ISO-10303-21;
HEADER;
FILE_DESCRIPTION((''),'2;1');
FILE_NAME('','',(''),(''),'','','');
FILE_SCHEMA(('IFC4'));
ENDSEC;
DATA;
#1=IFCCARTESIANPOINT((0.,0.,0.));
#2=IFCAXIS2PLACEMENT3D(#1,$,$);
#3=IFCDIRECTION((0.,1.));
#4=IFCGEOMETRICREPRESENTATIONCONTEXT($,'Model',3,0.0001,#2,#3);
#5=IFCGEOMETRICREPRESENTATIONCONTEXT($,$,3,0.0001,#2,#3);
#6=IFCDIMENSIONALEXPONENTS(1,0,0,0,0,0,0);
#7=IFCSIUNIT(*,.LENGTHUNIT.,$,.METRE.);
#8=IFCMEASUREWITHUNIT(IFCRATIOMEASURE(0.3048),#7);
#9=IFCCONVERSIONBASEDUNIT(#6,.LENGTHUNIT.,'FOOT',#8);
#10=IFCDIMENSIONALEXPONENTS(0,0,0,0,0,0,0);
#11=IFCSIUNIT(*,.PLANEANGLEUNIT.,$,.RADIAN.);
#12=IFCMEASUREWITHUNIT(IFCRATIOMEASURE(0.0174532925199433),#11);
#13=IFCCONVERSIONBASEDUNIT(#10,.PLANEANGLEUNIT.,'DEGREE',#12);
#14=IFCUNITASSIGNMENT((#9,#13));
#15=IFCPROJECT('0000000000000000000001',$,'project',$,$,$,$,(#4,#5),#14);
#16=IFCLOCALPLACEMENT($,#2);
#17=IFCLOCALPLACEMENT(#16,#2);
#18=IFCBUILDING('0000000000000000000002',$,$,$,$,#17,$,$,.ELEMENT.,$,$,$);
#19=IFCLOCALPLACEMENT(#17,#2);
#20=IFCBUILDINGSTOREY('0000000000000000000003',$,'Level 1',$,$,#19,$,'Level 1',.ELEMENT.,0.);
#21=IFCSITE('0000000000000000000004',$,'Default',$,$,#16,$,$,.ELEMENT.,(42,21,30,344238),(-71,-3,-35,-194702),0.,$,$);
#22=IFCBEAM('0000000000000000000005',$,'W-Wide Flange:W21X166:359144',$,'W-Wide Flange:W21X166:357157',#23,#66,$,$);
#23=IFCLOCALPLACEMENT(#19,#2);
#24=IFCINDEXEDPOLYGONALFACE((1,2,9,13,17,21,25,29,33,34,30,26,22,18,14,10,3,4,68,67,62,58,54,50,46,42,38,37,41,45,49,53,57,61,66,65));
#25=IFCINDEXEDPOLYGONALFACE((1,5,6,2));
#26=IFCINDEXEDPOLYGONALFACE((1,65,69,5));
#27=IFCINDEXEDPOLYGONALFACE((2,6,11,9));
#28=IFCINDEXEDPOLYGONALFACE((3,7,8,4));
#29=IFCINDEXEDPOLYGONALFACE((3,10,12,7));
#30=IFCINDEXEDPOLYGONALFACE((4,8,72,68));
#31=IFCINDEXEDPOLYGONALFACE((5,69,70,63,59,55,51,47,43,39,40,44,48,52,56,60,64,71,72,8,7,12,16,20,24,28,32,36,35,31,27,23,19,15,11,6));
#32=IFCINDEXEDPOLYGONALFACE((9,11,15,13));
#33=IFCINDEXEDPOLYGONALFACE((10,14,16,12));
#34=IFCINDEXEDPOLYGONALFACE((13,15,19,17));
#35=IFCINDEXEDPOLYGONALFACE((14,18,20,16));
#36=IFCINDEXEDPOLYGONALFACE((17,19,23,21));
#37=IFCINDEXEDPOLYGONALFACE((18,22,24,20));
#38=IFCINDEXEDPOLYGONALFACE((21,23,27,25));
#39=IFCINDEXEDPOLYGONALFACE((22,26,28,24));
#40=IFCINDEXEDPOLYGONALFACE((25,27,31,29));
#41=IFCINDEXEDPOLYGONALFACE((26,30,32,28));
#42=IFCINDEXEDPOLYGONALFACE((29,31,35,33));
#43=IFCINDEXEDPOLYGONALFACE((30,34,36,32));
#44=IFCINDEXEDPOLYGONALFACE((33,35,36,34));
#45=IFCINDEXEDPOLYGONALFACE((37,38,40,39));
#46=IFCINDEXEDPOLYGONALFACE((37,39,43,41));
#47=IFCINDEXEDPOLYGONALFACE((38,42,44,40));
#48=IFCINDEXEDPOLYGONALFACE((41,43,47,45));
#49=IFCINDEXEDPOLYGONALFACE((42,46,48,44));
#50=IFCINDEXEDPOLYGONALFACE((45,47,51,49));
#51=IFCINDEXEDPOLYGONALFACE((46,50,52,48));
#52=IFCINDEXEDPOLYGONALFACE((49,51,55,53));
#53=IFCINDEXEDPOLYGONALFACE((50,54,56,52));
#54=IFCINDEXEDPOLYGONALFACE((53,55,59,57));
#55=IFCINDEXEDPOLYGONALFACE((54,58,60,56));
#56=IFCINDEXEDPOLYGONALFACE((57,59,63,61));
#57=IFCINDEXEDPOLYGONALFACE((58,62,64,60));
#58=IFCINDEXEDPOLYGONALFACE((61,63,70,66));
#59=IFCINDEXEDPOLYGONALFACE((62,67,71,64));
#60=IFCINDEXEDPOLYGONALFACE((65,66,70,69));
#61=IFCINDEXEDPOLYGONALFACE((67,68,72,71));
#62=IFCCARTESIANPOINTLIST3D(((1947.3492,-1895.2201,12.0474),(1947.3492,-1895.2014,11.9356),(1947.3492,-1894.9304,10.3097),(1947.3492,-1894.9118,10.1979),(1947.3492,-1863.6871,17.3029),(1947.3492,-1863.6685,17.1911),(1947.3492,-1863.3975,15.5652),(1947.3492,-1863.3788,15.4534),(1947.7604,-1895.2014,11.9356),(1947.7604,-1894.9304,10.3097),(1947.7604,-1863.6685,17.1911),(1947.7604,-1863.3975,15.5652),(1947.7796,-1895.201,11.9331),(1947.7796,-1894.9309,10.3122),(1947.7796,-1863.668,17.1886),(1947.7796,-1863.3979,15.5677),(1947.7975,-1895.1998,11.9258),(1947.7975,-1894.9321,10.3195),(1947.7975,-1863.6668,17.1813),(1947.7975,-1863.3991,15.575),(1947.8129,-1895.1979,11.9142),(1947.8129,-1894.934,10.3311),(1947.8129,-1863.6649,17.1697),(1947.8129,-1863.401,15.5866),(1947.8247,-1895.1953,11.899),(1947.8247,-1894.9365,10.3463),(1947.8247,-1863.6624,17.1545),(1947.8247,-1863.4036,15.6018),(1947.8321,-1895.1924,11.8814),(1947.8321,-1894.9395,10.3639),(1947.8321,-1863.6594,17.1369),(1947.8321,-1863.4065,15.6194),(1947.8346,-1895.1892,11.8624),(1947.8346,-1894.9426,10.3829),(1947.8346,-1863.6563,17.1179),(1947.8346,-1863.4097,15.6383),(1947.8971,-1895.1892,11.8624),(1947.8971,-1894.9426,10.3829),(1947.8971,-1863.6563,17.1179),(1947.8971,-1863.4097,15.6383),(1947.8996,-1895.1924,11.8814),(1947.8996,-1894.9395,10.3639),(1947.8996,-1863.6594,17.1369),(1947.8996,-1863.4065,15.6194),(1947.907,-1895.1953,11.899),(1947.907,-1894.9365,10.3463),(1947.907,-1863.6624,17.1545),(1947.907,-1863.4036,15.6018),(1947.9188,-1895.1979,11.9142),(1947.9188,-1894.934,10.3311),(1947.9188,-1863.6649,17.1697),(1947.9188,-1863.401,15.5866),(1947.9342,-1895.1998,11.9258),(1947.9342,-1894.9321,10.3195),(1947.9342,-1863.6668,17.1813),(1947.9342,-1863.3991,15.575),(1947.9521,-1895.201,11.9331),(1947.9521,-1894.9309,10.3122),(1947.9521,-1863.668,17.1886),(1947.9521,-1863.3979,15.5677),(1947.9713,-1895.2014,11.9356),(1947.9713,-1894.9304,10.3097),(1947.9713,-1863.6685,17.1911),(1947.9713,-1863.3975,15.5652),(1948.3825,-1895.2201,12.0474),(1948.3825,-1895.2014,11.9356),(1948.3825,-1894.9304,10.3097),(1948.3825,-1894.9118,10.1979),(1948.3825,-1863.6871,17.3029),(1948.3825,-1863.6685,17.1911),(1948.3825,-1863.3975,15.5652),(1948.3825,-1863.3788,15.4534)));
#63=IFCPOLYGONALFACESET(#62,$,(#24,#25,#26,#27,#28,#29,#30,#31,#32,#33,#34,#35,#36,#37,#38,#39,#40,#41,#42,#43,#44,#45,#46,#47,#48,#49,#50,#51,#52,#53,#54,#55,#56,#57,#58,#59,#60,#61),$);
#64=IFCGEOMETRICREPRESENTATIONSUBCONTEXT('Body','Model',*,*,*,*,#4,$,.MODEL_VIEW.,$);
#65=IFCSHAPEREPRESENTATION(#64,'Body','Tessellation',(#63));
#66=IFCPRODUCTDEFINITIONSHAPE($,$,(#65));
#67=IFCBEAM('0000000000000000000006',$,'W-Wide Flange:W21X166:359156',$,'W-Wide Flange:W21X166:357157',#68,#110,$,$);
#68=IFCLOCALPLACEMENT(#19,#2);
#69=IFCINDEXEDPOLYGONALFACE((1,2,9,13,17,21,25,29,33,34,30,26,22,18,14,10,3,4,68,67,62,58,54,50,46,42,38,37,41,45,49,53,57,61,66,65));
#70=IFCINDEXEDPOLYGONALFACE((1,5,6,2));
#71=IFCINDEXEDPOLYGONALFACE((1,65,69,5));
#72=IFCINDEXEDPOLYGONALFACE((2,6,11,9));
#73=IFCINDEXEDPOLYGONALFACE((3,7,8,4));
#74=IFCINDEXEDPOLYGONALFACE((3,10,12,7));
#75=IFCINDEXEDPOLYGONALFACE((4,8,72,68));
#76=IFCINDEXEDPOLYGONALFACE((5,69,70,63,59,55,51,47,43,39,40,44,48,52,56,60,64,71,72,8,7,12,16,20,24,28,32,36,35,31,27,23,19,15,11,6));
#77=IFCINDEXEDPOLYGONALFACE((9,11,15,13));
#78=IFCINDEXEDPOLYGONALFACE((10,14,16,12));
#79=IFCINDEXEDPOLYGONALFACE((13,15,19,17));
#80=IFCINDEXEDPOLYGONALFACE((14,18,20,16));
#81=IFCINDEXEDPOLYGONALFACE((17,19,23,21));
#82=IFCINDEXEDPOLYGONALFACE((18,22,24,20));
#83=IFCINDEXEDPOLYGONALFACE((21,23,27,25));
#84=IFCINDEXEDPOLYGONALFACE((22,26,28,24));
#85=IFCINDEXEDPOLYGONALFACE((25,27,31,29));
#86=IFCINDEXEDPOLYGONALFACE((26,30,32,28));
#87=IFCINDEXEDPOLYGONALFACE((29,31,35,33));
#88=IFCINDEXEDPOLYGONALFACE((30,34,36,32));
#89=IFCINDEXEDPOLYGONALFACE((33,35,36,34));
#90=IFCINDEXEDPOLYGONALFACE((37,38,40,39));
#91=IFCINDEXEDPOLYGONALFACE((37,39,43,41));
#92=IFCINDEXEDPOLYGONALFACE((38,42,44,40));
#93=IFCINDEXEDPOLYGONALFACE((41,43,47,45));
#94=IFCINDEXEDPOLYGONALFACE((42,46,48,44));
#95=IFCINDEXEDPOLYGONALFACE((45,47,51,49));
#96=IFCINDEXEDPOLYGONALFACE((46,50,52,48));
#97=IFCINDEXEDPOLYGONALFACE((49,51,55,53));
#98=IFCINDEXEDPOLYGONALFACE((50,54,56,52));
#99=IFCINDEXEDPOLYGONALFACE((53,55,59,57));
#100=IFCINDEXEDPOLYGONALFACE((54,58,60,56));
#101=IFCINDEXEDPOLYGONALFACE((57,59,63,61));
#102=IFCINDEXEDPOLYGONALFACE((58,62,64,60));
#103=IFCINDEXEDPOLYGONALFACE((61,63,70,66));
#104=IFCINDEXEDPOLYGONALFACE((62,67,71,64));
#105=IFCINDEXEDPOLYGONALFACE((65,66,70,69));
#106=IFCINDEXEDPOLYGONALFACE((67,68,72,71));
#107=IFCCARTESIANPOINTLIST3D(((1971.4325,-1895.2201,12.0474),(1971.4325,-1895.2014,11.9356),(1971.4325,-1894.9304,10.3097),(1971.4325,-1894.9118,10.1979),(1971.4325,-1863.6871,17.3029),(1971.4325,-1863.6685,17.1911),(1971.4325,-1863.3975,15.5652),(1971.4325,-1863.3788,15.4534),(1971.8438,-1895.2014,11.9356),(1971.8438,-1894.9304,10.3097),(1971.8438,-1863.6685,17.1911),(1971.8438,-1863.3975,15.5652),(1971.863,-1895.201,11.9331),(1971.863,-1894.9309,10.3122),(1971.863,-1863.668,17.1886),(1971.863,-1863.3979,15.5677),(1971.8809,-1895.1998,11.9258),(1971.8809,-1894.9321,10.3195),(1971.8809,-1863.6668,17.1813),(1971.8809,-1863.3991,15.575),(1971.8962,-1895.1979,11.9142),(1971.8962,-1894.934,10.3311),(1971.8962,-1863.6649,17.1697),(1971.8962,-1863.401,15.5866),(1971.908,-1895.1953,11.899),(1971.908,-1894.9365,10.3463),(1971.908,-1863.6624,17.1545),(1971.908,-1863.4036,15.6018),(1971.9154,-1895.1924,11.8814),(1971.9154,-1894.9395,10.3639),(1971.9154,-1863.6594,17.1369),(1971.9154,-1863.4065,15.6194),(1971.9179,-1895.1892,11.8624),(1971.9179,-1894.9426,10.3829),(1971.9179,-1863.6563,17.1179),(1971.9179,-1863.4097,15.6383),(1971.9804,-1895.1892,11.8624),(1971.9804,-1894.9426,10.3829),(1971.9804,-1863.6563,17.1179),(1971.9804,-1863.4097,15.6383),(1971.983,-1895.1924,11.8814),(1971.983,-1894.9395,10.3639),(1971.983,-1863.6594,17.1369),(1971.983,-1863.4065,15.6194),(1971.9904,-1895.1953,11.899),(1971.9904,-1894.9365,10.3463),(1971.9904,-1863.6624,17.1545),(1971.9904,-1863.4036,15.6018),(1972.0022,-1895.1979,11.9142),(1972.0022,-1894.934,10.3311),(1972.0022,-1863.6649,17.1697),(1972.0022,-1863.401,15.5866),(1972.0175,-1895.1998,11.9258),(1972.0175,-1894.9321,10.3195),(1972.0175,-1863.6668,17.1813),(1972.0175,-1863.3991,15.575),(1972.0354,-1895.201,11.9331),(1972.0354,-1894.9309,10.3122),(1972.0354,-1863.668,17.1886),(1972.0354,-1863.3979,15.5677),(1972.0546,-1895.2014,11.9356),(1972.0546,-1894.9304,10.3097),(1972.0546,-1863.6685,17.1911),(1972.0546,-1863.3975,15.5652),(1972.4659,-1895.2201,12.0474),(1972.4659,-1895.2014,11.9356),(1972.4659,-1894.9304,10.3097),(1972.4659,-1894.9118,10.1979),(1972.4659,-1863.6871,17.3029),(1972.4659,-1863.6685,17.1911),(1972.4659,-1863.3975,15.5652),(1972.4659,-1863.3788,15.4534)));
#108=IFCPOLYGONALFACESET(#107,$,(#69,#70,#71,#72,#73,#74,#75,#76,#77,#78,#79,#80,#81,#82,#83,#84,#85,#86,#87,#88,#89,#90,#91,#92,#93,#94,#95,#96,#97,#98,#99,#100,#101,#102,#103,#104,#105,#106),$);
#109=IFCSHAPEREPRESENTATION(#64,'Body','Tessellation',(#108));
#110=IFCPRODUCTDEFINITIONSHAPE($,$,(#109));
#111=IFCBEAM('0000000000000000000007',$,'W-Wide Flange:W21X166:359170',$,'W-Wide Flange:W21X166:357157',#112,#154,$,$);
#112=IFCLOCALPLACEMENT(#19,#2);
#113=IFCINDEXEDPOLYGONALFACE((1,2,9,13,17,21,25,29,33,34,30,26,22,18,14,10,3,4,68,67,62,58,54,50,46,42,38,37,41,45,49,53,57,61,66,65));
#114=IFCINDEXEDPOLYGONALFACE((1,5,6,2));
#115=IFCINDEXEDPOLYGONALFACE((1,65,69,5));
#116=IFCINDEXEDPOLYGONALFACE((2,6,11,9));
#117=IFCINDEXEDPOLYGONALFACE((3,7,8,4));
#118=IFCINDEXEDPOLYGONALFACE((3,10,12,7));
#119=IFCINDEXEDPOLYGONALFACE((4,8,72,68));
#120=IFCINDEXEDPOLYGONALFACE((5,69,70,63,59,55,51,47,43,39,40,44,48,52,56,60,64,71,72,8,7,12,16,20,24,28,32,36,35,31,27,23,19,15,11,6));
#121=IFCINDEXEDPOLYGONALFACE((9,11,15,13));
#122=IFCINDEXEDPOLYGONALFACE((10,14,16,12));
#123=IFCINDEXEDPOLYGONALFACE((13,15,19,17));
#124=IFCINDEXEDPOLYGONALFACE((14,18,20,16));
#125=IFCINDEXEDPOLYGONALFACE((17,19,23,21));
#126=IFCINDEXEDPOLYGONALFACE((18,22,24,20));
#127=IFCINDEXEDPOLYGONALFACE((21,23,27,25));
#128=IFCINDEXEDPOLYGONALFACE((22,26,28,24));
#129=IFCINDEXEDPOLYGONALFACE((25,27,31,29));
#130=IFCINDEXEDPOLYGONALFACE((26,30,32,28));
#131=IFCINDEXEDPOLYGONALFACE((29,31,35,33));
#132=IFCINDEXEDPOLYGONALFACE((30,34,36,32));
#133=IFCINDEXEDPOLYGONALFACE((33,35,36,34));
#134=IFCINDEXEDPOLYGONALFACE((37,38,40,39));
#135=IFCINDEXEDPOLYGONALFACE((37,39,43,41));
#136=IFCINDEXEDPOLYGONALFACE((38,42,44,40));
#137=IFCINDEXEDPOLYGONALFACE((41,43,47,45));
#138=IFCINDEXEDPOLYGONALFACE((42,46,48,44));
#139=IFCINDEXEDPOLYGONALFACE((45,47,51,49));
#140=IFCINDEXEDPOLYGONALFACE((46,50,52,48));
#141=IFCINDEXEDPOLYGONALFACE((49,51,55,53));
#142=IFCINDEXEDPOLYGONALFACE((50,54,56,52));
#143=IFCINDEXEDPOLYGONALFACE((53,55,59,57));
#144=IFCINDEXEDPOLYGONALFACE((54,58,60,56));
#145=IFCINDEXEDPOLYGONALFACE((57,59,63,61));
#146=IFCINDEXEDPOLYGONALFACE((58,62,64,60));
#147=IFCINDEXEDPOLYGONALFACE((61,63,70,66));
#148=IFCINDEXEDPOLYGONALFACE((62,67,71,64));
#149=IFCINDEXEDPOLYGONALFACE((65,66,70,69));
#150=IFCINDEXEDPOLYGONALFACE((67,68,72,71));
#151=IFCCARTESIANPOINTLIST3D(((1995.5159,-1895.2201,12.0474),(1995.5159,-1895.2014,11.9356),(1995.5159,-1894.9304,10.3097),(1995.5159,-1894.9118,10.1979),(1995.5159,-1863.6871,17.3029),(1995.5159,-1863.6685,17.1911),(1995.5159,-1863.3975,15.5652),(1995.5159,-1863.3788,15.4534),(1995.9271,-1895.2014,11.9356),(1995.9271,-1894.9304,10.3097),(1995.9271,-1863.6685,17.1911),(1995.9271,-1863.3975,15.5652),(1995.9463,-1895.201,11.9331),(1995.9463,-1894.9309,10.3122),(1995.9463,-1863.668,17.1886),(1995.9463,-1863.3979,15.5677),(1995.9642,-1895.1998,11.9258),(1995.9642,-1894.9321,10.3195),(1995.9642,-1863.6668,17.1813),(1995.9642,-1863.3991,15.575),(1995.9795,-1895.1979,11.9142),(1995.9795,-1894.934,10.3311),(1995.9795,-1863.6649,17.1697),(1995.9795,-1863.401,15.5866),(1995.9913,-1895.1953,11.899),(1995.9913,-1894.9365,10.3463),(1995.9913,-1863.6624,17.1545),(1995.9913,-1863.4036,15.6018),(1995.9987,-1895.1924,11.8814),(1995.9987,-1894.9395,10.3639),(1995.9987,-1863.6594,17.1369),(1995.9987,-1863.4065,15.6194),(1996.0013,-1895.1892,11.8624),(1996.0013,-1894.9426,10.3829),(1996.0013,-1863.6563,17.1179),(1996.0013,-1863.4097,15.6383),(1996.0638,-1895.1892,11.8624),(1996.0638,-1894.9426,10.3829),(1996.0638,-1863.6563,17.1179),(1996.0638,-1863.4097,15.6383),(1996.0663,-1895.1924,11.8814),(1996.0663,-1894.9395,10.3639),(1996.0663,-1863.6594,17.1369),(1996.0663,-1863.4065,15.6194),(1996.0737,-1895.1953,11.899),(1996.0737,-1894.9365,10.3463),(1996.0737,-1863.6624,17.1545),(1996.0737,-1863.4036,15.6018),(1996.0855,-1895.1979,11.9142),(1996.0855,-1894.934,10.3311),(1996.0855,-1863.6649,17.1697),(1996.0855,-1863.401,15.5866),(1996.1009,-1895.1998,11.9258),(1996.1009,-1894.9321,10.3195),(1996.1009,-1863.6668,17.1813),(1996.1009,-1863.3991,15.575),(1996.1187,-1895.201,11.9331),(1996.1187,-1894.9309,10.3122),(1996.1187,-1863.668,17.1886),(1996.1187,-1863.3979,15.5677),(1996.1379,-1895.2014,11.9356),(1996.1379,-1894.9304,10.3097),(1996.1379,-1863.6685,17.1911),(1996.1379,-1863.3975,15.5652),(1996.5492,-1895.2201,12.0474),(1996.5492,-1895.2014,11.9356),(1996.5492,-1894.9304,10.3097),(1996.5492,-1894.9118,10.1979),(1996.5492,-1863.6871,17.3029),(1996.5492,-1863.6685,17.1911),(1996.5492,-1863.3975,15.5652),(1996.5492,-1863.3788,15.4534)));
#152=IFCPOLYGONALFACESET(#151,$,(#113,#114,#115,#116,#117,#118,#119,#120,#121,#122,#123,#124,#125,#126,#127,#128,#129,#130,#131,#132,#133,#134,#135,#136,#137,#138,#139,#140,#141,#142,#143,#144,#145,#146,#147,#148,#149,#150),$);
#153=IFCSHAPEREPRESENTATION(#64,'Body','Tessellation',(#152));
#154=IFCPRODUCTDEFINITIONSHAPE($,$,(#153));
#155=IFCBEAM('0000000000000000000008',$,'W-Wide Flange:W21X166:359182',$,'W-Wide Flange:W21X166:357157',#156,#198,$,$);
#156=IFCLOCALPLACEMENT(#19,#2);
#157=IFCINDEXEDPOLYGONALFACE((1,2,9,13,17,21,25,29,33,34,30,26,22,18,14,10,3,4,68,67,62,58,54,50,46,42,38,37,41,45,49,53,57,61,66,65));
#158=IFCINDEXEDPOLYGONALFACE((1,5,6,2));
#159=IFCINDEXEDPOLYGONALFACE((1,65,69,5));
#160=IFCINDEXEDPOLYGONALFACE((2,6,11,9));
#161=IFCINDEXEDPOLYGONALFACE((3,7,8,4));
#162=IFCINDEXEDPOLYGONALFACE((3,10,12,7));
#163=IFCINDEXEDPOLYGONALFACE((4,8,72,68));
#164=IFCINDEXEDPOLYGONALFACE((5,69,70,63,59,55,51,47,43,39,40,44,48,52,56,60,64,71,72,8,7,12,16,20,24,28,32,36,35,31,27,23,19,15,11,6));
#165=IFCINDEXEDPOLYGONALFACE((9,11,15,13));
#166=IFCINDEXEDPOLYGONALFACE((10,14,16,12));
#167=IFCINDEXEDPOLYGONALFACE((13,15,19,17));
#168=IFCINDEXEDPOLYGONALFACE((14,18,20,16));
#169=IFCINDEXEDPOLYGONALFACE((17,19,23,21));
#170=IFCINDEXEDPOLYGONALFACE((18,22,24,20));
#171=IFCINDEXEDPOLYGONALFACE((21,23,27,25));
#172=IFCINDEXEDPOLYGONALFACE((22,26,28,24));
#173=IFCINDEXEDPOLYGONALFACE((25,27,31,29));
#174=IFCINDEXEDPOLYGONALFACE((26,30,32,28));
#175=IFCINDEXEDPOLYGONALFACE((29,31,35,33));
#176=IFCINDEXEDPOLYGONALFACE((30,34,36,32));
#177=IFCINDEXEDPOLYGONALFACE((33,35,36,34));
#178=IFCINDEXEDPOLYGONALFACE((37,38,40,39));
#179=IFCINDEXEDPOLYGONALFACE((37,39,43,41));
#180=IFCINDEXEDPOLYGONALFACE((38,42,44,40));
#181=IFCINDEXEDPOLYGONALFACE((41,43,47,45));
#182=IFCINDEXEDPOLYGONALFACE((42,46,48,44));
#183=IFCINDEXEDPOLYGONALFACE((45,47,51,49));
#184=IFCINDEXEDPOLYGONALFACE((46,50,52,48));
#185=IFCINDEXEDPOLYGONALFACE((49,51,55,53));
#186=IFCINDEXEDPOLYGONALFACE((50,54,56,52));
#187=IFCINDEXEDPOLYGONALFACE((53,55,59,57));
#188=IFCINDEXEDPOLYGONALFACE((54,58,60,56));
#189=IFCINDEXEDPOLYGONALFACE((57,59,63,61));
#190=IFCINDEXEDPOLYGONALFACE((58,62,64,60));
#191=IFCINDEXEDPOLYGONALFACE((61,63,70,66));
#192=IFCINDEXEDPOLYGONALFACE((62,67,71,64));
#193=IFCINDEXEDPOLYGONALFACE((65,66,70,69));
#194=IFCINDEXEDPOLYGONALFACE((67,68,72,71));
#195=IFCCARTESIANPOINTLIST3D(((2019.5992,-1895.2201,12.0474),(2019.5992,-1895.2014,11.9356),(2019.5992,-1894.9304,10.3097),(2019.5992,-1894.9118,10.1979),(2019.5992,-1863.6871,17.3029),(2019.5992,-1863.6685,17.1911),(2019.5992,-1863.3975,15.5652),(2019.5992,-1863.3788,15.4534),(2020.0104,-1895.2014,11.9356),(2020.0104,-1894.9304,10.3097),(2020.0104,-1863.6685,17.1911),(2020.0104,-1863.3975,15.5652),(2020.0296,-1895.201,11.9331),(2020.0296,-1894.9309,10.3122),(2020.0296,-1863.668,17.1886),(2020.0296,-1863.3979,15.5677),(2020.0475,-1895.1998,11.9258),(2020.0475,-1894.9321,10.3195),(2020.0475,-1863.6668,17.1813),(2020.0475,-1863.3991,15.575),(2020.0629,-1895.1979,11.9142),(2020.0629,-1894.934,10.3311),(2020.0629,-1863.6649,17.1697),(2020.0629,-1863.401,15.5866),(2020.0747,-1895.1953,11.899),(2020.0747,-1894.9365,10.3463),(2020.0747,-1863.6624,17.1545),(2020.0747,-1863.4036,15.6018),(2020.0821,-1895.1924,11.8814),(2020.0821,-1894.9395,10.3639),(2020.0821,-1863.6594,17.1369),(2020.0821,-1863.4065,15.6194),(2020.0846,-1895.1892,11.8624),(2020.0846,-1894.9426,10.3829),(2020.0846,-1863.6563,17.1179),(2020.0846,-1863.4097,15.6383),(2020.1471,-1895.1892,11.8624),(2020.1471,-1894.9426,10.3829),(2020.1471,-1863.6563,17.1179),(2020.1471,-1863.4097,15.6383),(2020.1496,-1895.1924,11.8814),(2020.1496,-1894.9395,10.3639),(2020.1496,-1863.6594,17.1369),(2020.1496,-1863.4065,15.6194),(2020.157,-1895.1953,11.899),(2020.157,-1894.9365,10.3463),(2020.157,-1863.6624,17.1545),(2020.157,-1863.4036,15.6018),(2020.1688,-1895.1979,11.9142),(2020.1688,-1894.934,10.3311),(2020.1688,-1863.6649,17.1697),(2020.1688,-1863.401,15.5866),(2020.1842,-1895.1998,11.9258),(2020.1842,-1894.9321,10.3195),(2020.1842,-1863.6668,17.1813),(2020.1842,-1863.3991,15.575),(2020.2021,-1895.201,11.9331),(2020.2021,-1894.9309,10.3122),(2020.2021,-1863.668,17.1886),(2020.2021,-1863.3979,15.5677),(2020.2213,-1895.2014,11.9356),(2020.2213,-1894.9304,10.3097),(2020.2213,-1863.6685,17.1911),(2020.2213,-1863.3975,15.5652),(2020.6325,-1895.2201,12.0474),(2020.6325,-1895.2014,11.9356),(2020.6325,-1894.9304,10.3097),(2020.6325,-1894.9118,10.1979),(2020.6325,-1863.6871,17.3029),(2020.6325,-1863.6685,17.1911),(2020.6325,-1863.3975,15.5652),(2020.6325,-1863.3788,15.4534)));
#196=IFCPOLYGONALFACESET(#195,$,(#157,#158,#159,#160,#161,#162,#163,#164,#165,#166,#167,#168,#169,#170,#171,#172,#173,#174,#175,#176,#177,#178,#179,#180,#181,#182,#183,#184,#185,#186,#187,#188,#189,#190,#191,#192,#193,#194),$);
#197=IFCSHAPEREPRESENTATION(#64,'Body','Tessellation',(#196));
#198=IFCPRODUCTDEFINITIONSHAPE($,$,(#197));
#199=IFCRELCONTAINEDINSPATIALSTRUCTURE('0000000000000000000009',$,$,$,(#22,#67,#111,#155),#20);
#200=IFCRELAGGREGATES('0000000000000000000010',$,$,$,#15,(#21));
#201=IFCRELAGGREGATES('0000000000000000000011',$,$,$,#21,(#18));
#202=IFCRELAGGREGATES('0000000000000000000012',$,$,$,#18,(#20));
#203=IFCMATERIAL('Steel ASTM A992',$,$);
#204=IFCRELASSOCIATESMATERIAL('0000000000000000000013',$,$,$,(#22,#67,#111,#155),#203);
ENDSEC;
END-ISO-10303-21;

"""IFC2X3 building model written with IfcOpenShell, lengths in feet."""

from ifc_helpers import new_model, entity, si_unit, converted_unit, direction, frame, frame_2d, origin, place, context, subcontext, project, spatial, i_section, extrude, material, element, save


model = new_model("IFC2X3")

# Units and contexts
model_context = context("Model", 3, precision=0.0001, world=origin(), true_north=direction((0.0, 1.0)))
context_of_model = context(None, 3, precision=0.0001, world=origin(), true_north=direction((0.0, 1.0)))
body_context = subcontext(model_context, "Body", "Model", "MODEL_VIEW")
ifc_project = project(units=[converted_unit("LENGTHUNIT", "FOOT", entity("IfcRatioMeasure", 0.3048), si_unit("LENGTHUNIT", "METRE"), dimensions=[1, 0, 0, 0, 0, 0, 0]), converted_unit("PLANEANGLEUNIT", "DEGREE", entity("IfcRatioMeasure", 0.0174532925199433), si_unit("PLANEANGLEUNIT", "RADIAN"), dimensions=[0, 0, 0, 0, 0, 0, 0])], contexts=[model_context, context_of_model])

# Site, building, storey
site_placement = place(None, origin())
site = spatial("IfcSite", under=ifc_project, at=site_placement, Name="Default", CompositionType="ELEMENT", RefLatitude=(42, 21, 30, 344238), RefLongitude=(-71, -3, -35, -194702), RefElevation=0.0)
building_placement = place(site_placement, origin())
building = spatial("IfcBuilding", under=site, at=building_placement, CompositionType="ELEMENT")
storey_placement = place(building_placement, origin())
storey = spatial("IfcBuildingStorey", under=building, at=storey_placement, Name="Level 1", LongName="Level 1", CompositionType="ELEMENT", Elevation=0.0)

# Beams
ifc_material_1 = material(Name="Steel ASTM A992")
beam_1_placement = place(storey_placement, frame((1947.8659, -1895.6585, 11.9743), z_axis=(0.0, -0.164399, 0.986394), x_axis=(0.0, 0.986394, 0.164399)))
element("IfcBeam", 1, at=beam_1_placement, inside=storey, material=ifc_material_1, Name="W-Wide Flange:W21X166:359144", ObjectType="W-Wide Flange:W21X166:357157", context=body_context, shape_type="SweptSolid", body=[
    extrude(i_section(OverallWidth=1.0333, OverallDepth=1.875, WebThickness=0.0625, FlangeThickness=0.1133, FilletRadius=0.0742, at=frame_2d((0.0, 0.0), x_axis=(0.0, 1.0))), frame((0.4445, 0.0, -0.9375), z_axis=(1.0, 0.0, 0.0), x_axis=(0.0, 0.0, -1.0)), (0.0, 0.0, 1.0), 31.9679),
])
beam_2_placement = place(storey_placement, frame((1971.9492, -1895.6585, 11.9743), z_axis=(0.0, -0.164399, 0.986394), x_axis=(0.0, 0.986394, 0.164399)))
element("IfcBeam", 2, at=beam_2_placement, inside=storey, material=ifc_material_1, Name="W-Wide Flange:W21X166:359156", ObjectType="W-Wide Flange:W21X166:357157", context=body_context, shape_type="SweptSolid", body=[
    extrude(i_section(OverallWidth=1.0333, OverallDepth=1.875, WebThickness=0.0625, FlangeThickness=0.1133, FilletRadius=0.0742, at=frame_2d((0.0, 0.0), x_axis=(0.0, 1.0))), frame((0.4445, 0.0, -0.9375), z_axis=(1.0, 0.0, 0.0), x_axis=(0.0, 0.0, -1.0)), (0.0, 0.0, 1.0), 31.9679),
])
beam_3_placement = place(storey_placement, frame((1996.0325, -1895.6585, 11.9743), z_axis=(0.0, -0.164399, 0.986394), x_axis=(0.0, 0.986394, 0.164399)))
element("IfcBeam", 3, at=beam_3_placement, inside=storey, material=ifc_material_1, Name="W-Wide Flange:W21X166:359170", ObjectType="W-Wide Flange:W21X166:357157", context=body_context, shape_type="SweptSolid", body=[
    extrude(i_section(OverallWidth=1.0333, OverallDepth=1.875, WebThickness=0.0625, FlangeThickness=0.1133, FilletRadius=0.0742, at=frame_2d((0.0, 0.0), x_axis=(0.0, 1.0))), frame((0.4445, 0.0, -0.9375), z_axis=(1.0, 0.0, 0.0), x_axis=(0.0, 0.0, -1.0)), (0.0, 0.0, 1.0), 31.9679),
])
beam_4_placement = place(storey_placement, frame((2020.1159, -1895.6585, 11.9743), z_axis=(0.0, -0.164399, 0.986394), x_axis=(0.0, 0.986394, 0.164399)))
element("IfcBeam", 4, at=beam_4_placement, inside=storey, material=ifc_material_1, Name="W-Wide Flange:W21X166:359182", ObjectType="W-Wide Flange:W21X166:357157", context=body_context, shape_type="SweptSolid", body=[
    extrude(i_section(OverallWidth=1.0333, OverallDepth=1.875, WebThickness=0.0625, FlangeThickness=0.1133, FilletRadius=0.0742, at=frame_2d((0.0, 0.0), x_axis=(0.0, 1.0))), frame((0.4445, 0.0, -0.9375), z_axis=(1.0, 0.0, 0.0), x_axis=(0.0, 0.0, -1.0)), (0.0, 0.0, 1.0), 31.9679),
])

save(model, "model.ifc")
